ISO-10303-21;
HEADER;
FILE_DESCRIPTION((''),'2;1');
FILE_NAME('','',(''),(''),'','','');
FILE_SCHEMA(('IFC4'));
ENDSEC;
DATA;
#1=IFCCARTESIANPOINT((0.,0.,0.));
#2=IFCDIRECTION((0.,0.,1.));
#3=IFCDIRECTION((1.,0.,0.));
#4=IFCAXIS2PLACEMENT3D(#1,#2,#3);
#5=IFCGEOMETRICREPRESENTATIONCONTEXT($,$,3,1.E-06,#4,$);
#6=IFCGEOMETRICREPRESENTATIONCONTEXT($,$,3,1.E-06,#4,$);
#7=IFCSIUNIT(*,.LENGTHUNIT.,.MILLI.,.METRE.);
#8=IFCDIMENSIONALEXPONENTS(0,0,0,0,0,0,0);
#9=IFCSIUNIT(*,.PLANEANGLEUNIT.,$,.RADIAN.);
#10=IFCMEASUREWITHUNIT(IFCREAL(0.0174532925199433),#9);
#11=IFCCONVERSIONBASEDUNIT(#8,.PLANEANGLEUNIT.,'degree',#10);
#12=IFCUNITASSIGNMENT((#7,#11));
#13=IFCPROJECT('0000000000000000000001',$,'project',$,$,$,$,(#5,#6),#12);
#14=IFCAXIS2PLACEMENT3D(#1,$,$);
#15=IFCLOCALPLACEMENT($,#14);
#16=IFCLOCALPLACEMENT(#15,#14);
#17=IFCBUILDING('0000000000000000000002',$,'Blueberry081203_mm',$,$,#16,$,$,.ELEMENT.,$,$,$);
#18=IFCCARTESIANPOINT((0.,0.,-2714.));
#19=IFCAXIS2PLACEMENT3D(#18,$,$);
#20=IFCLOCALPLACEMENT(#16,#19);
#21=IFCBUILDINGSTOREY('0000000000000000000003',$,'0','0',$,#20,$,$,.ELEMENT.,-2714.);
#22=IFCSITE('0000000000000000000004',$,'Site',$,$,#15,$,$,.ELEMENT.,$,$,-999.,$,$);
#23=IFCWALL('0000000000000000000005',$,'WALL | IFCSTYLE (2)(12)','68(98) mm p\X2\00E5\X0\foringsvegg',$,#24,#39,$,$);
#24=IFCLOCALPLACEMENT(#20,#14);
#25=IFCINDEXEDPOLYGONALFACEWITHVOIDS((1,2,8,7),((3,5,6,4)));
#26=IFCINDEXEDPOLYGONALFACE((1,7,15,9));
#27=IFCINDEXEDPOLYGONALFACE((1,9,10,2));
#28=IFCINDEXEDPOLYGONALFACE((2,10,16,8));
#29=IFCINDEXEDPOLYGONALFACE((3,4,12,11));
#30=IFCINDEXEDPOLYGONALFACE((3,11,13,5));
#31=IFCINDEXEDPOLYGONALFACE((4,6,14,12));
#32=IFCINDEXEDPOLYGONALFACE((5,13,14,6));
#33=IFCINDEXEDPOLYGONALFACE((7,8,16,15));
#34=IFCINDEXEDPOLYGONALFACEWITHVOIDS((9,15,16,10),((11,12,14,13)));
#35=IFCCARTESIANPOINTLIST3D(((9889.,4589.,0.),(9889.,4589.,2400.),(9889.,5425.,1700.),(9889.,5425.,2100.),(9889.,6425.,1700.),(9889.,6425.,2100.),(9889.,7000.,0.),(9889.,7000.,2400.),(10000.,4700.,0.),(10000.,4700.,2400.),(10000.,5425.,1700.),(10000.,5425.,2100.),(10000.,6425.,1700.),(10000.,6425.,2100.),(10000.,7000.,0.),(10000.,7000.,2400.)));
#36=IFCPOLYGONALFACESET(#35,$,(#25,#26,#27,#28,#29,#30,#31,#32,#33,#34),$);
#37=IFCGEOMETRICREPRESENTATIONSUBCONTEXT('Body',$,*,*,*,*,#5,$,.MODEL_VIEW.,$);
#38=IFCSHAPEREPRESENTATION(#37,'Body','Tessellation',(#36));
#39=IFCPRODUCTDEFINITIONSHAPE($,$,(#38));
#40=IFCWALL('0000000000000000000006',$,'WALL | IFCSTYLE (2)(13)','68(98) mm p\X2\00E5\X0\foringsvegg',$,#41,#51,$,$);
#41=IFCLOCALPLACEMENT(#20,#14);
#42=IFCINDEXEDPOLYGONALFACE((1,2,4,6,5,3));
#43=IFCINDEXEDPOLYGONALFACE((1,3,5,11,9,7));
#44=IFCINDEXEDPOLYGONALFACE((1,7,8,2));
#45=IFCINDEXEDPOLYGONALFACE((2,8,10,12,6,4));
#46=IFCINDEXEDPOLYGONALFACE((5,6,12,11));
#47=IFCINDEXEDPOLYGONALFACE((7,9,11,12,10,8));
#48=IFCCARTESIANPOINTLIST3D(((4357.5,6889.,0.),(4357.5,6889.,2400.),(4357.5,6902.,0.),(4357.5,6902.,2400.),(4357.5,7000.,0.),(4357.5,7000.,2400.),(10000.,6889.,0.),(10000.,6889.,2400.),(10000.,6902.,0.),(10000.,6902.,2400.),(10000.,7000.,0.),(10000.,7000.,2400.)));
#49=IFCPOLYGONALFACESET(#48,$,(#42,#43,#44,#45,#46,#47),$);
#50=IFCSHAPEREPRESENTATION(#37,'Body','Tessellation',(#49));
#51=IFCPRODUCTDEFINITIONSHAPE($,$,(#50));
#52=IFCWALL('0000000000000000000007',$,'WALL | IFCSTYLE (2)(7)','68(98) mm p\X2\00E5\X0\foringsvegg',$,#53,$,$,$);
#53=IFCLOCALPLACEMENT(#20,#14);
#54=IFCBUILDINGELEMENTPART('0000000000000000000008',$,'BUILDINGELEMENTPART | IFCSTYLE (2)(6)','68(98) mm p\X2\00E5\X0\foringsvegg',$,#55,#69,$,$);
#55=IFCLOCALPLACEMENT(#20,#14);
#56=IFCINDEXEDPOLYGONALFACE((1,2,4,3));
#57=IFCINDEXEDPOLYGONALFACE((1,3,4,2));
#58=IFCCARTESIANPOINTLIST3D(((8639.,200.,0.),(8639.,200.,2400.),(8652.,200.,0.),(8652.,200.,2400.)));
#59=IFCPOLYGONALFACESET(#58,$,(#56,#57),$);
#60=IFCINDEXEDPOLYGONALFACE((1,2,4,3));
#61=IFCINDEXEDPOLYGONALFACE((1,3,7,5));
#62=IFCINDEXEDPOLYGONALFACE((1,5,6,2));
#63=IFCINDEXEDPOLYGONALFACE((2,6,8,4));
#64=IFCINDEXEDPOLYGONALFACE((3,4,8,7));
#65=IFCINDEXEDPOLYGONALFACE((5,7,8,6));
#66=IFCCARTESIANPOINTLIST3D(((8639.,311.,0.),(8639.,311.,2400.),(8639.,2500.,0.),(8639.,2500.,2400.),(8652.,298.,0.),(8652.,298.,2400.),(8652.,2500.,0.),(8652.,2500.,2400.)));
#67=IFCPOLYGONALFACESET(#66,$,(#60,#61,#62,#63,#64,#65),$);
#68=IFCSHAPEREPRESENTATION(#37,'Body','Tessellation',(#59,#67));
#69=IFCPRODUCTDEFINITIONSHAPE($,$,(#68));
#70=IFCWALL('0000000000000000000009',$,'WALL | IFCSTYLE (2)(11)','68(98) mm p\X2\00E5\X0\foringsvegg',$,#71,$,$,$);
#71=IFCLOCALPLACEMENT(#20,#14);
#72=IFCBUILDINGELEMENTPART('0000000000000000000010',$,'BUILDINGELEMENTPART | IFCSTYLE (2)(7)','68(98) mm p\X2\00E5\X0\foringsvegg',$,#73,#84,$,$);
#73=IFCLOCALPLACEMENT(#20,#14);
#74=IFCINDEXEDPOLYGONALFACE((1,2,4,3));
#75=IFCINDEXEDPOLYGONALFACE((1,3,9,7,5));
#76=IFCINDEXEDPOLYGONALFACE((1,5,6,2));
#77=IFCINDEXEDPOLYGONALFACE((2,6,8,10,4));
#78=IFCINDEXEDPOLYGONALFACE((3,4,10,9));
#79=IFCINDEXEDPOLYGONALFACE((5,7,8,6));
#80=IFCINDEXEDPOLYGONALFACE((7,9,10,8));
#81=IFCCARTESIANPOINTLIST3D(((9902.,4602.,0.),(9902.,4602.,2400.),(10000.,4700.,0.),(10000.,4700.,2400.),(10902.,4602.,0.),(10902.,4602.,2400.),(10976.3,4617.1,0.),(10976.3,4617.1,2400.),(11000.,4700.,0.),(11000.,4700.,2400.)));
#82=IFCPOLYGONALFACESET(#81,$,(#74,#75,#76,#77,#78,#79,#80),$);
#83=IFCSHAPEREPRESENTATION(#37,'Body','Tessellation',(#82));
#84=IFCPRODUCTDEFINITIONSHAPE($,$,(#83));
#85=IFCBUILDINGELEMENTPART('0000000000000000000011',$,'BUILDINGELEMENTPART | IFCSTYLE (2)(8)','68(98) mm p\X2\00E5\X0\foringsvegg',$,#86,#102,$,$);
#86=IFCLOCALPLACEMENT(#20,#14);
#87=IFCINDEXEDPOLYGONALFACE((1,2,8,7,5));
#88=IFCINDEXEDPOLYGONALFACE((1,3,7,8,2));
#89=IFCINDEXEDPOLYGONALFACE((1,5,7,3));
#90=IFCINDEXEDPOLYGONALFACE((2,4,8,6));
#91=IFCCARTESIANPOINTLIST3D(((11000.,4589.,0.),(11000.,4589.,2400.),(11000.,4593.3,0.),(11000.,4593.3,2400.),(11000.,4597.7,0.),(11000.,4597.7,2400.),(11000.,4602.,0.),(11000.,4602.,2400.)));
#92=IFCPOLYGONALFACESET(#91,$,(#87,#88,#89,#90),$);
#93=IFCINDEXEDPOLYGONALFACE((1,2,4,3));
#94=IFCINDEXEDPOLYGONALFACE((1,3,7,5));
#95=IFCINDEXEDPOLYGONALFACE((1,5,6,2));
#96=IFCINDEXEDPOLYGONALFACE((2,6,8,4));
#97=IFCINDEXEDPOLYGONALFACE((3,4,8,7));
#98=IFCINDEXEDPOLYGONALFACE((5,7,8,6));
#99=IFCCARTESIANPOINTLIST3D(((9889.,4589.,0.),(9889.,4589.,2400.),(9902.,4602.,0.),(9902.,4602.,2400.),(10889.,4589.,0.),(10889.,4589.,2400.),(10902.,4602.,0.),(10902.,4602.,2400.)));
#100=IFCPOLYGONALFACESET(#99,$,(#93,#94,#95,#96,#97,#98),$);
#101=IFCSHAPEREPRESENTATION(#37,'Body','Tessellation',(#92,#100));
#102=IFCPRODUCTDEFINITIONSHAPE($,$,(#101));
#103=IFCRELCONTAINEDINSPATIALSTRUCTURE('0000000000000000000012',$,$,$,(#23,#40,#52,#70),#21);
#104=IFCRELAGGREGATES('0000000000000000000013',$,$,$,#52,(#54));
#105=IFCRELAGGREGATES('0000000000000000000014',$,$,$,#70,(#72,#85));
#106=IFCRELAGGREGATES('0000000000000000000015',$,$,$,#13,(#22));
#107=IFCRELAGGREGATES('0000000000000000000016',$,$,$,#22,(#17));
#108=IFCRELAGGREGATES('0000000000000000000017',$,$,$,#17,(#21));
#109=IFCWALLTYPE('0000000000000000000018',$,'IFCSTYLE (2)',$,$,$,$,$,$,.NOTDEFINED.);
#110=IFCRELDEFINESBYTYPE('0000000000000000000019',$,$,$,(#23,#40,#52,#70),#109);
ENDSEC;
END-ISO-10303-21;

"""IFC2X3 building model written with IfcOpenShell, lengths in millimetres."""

from ifc_helpers import new_model, entity, si_unit, converted_unit, frame, frame_2d, origin, origin_with_axes, origin_2d_with_axis, place, context, subcontext, project, spatial, polyline, segment, composite_curve, rectangle, outline, extrude, type_object, element, aggregate, save


model = new_model("IFC2X3")

# Units and contexts
context_of_model_1 = context(None, 3, precision=1e-06, world=origin_with_axes())
context_of_model_2 = context(None, 3, precision=1e-06, world=origin_with_axes())
body_context = subcontext(context_of_model_1, "Body", None, "MODEL_VIEW")
ifc_project = project(units=[si_unit("LENGTHUNIT", "METRE", prefix="MILLI"), converted_unit("PLANEANGLEUNIT", "degree", entity("IfcReal", 0.0174532925199433), si_unit("PLANEANGLEUNIT", "RADIAN"), dimensions=[0, 0, 0, 0, 0, 0, 0])], contexts=[context_of_model_1, context_of_model_2])

# Site, building, storey
site_placement = place(None, origin())
site = spatial("IfcSite", under=ifc_project, at=site_placement, Name="Site", CompositionType="ELEMENT", RefElevation=-999.0)
building_placement = place(site_placement, origin())
building = spatial("IfcBuilding", under=site, at=building_placement, Name="Blueberry081203_mm", CompositionType="ELEMENT")
storey_placement = place(building_placement, frame((0.0, 0.0, -2714.0)))
storey = spatial("IfcBuildingStorey", under=building, at=storey_placement, Name="0", Description="0", CompositionType="ELEMENT", Elevation=-2714.0)

# Shared definitions
wall_type_1 = type_object("IfcWallType", Name="IFCSTYLE (2)", PredefinedType="NOTDEFINED")

# Wall, opening
wall_1_placement = place(storey_placement, frame((10000.0, 4700.0, 0.0), z_axis=(0.0, 0.0, 1.0), x_axis=(0.0, 1.0, 0.0)))
wall_1 = element("IfcWall", 1, at=wall_1_placement, inside=storey, type_object=wall_type_1, Name="WALL | IFCSTYLE (2)(12)", Description="68(98) mm påforingsvegg", context=body_context, shape_type="SweptSolid", held_by="IfcProductRepresentation", body=[
    extrude(outline(composite_curve([segment(polyline([(-98.0, 98.0), (0.0, 0.0)]), True, "CONTINUOUS"), segment(polyline([(0.0, 0.0), (2300.0, 0.0)]), True, "CONTINUOUS"), segment(polyline([(2300.0, 0.0), (2300.0, 98.0)]), True, "CONTINUOUS"), segment(polyline([(2300.0, 98.0), (2300.0, 111.0)]), True, "CONTINUOUS"), segment(polyline([(2300.0, 111.0), (-111.0, 111.0)]), True, "CONTINUOUS"), segment(polyline([(-111.0, 111.0), (-98.0, 98.0)]), True, "CONTINUOUS")], self_intersect=False)), origin(), (0.0, 0.0, 1.0), 2400.0),
])
opening_1_placement = place(wall_1_placement, frame((725.0, 55.5, 1700.0)))
element("IfcOpeningElement", 2, at=opening_1_placement, cuts=wall_1, context=body_context, shape_type="SweptSolid", held_by="IfcProductRepresentation", body=[
    extrude(rectangle(XDim=1000.0, YDim=400.0, at=origin_2d_with_axis()), frame((500.0, 55.5, 200.0), z_axis=(0.0, -1.0, 0.0), x_axis=(1.0, 0.0, 0.0)), (0.0, 0.0, 1.0), 111.0),
])

# Wall
wall_2_placement = place(storey_placement, frame((10000.0, 7000.0, 0.0), z_axis=(0.0, 0.0, 1.0), x_axis=(-1.0, 0.0, 0.0)))
element("IfcWall", 3, at=wall_2_placement, inside=storey, type_object=wall_type_1, Name="WALL | IFCSTYLE (2)(13)", Description="68(98) mm påforingsvegg", context=body_context, shape_type="SweptSolid", held_by="IfcProductRepresentation", body=[
    extrude(outline(composite_curve([segment(polyline([(0.0, 98.0), (0.0, 0.0)]), True, "CONTINUOUS"), segment(polyline([(0.0, 0.0), (5642.5, 0.0)]), True, "CONTINUOUS"), segment(polyline([(5642.5, 0.0), (5642.5, 98.0)]), True, "CONTINUOUS"), segment(polyline([(5642.5, 98.0), (5642.5, 111.0)]), True, "CONTINUOUS"), segment(polyline([(5642.5, 111.0), (0.0, 111.0)]), True, "CONTINUOUS"), segment(polyline([(0.0, 111.0), (0.0, 98.0)]), True, "CONTINUOUS")], self_intersect=False)), origin(), (0.0, 0.0, 1.0), 2400.0),
])

# Walls, building element parts
wall_3_placement = place(storey_placement, frame((8750.0, 200.0, 0.0), z_axis=(0.0, 0.0, 1.0), x_axis=(0.0, 1.0, 0.0)))
wall_3 = element("IfcWall", 4, at=wall_3_placement, inside=storey, type_object=wall_type_1, Name="WALL | IFCSTYLE (2)(7)", Description="68(98) mm påforingsvegg")
building_element_part_1_placement = place(wall_3_placement, origin())
building_element_part_1 = element("IfcBuildingElementPart", 5, at=building_element_part_1_placement, Name="BUILDINGELEMENTPART | IFCSTYLE (2)(6)", Description="68(98) mm påforingsvegg", context=body_context, shape_type="SweptSolid", held_by="IfcProductRepresentation", body=[
    extrude(outline(composite_curve([segment(polyline([(0.0, 111.0), (0.0, 98.0)]), True, "CONTINUOUS"), segment(polyline([(0.0, 98.0), (0.0, 98.0)]), True, "CONTINUOUS"), segment(polyline([(0.0, 98.0), (0.0, 111.0)]), True, "CONTINUOUS"), segment(polyline([(0.0, 111.0), (0.0, 111.0)]), True, "CONTINUOUS")], self_intersect=False)), origin(), (0.0, 0.0, 1.0), 2400.0),
    extrude(outline(composite_curve([segment(polyline([(111.0, 111.0), (98.0, 98.0)]), True, "CONTINUOUS"), segment(polyline([(98.0, 98.0), (2300.0, 98.0)]), True, "CONTINUOUS"), segment(polyline([(2300.0, 98.0), (2300.0, 111.0)]), True, "CONTINUOUS"), segment(polyline([(2300.0, 111.0), (111.0, 111.0)]), True, "CONTINUOUS")], self_intersect=False)), origin(), (0.0, 0.0, 1.0), 2400.0),
])
aggregate(wall_3, [building_element_part_1])
wall_4_placement = place(storey_placement, frame((11000.0, 4700.0, 0.0), z_axis=(0.0, 0.0, 1.0), x_axis=(-1.0, 0.0, 0.0)))
wall_4 = element("IfcWall", 6, at=wall_4_placement, inside=storey, type_object=wall_type_1, Name="WALL | IFCSTYLE (2)(11)", Description="68(98) mm påforingsvegg")
building_element_part_2_placement = place(wall_4_placement, origin())
building_element_part_2 = element("IfcBuildingElementPart", 7, at=building_element_part_2_placement, Name="BUILDINGELEMENTPART | IFCSTYLE (2)(7)", Description="68(98) mm påforingsvegg", context=body_context, shape_type="SweptSolid", held_by="IfcProductRepresentation", body=[
    extrude(rectangle(XDim=98.0, YDim=0.0, at=frame_2d((0.0, 49.0), x_axis=(0.0, -1.0))), origin(), (0.0, 0.0, 1.0), 2400.0),
    extrude(outline(composite_curve([segment(polyline([(98.0, 98.0), (23.7, 82.9)]), True, "CONTINUOUS"), segment(polyline([(23.7, 82.9), (0.0, 0.0)]), True, "CONTINUOUS"), segment(polyline([(0.0, 0.0), (1000.0, 0.0)]), True, "CONTINUOUS"), segment(polyline([(1000.0, 0.0), (1098.0, 98.0)]), True, "CONTINUOUS"), segment(polyline([(1098.0, 98.0), (98.0, 98.0)]), True, "CONTINUOUS")], self_intersect=False)), origin(), (0.0, 0.0, 1.0), 2400.0),
])
building_element_part_3_placement = place(wall_4_placement, origin())
building_element_part_3 = element("IfcBuildingElementPart", 8, at=building_element_part_3_placement, Name="BUILDINGELEMENTPART | IFCSTYLE (2)(8)", Description="68(98) mm påforingsvegg", context=body_context, shape_type="SweptSolid", held_by="IfcProductRepresentation", body=[
    extrude(outline(composite_curve([segment(polyline([(0.0, 111.0), (0.0, 98.0)]), True, "CONTINUOUS"), segment(polyline([(0.0, 98.0), (0.0, 98.0)]), True, "CONTINUOUS"), segment(polyline([(0.0, 98.0), (0.0, 111.0)]), True, "CONTINUOUS"), segment(polyline([(0.0, 111.0), (0.0, 111.0)]), True, "CONTINUOUS")], self_intersect=False)), origin(), (0.0, 0.0, 1.0), 2400.0),
    extrude(outline(composite_curve([segment(polyline([(111.0, 111.0), (98.0, 98.0)]), True, "CONTINUOUS"), segment(polyline([(98.0, 98.0), (1098.0, 98.0)]), True, "CONTINUOUS"), segment(polyline([(1098.0, 98.0), (1111.0, 111.0)]), True, "CONTINUOUS"), segment(polyline([(1111.0, 111.0), (111.0, 111.0)]), True, "CONTINUOUS")], self_intersect=False)), origin(), (0.0, 0.0, 1.0), 2400.0),
])
aggregate(wall_4, [building_element_part_2, building_element_part_3])

save(model, "model.ifc")
